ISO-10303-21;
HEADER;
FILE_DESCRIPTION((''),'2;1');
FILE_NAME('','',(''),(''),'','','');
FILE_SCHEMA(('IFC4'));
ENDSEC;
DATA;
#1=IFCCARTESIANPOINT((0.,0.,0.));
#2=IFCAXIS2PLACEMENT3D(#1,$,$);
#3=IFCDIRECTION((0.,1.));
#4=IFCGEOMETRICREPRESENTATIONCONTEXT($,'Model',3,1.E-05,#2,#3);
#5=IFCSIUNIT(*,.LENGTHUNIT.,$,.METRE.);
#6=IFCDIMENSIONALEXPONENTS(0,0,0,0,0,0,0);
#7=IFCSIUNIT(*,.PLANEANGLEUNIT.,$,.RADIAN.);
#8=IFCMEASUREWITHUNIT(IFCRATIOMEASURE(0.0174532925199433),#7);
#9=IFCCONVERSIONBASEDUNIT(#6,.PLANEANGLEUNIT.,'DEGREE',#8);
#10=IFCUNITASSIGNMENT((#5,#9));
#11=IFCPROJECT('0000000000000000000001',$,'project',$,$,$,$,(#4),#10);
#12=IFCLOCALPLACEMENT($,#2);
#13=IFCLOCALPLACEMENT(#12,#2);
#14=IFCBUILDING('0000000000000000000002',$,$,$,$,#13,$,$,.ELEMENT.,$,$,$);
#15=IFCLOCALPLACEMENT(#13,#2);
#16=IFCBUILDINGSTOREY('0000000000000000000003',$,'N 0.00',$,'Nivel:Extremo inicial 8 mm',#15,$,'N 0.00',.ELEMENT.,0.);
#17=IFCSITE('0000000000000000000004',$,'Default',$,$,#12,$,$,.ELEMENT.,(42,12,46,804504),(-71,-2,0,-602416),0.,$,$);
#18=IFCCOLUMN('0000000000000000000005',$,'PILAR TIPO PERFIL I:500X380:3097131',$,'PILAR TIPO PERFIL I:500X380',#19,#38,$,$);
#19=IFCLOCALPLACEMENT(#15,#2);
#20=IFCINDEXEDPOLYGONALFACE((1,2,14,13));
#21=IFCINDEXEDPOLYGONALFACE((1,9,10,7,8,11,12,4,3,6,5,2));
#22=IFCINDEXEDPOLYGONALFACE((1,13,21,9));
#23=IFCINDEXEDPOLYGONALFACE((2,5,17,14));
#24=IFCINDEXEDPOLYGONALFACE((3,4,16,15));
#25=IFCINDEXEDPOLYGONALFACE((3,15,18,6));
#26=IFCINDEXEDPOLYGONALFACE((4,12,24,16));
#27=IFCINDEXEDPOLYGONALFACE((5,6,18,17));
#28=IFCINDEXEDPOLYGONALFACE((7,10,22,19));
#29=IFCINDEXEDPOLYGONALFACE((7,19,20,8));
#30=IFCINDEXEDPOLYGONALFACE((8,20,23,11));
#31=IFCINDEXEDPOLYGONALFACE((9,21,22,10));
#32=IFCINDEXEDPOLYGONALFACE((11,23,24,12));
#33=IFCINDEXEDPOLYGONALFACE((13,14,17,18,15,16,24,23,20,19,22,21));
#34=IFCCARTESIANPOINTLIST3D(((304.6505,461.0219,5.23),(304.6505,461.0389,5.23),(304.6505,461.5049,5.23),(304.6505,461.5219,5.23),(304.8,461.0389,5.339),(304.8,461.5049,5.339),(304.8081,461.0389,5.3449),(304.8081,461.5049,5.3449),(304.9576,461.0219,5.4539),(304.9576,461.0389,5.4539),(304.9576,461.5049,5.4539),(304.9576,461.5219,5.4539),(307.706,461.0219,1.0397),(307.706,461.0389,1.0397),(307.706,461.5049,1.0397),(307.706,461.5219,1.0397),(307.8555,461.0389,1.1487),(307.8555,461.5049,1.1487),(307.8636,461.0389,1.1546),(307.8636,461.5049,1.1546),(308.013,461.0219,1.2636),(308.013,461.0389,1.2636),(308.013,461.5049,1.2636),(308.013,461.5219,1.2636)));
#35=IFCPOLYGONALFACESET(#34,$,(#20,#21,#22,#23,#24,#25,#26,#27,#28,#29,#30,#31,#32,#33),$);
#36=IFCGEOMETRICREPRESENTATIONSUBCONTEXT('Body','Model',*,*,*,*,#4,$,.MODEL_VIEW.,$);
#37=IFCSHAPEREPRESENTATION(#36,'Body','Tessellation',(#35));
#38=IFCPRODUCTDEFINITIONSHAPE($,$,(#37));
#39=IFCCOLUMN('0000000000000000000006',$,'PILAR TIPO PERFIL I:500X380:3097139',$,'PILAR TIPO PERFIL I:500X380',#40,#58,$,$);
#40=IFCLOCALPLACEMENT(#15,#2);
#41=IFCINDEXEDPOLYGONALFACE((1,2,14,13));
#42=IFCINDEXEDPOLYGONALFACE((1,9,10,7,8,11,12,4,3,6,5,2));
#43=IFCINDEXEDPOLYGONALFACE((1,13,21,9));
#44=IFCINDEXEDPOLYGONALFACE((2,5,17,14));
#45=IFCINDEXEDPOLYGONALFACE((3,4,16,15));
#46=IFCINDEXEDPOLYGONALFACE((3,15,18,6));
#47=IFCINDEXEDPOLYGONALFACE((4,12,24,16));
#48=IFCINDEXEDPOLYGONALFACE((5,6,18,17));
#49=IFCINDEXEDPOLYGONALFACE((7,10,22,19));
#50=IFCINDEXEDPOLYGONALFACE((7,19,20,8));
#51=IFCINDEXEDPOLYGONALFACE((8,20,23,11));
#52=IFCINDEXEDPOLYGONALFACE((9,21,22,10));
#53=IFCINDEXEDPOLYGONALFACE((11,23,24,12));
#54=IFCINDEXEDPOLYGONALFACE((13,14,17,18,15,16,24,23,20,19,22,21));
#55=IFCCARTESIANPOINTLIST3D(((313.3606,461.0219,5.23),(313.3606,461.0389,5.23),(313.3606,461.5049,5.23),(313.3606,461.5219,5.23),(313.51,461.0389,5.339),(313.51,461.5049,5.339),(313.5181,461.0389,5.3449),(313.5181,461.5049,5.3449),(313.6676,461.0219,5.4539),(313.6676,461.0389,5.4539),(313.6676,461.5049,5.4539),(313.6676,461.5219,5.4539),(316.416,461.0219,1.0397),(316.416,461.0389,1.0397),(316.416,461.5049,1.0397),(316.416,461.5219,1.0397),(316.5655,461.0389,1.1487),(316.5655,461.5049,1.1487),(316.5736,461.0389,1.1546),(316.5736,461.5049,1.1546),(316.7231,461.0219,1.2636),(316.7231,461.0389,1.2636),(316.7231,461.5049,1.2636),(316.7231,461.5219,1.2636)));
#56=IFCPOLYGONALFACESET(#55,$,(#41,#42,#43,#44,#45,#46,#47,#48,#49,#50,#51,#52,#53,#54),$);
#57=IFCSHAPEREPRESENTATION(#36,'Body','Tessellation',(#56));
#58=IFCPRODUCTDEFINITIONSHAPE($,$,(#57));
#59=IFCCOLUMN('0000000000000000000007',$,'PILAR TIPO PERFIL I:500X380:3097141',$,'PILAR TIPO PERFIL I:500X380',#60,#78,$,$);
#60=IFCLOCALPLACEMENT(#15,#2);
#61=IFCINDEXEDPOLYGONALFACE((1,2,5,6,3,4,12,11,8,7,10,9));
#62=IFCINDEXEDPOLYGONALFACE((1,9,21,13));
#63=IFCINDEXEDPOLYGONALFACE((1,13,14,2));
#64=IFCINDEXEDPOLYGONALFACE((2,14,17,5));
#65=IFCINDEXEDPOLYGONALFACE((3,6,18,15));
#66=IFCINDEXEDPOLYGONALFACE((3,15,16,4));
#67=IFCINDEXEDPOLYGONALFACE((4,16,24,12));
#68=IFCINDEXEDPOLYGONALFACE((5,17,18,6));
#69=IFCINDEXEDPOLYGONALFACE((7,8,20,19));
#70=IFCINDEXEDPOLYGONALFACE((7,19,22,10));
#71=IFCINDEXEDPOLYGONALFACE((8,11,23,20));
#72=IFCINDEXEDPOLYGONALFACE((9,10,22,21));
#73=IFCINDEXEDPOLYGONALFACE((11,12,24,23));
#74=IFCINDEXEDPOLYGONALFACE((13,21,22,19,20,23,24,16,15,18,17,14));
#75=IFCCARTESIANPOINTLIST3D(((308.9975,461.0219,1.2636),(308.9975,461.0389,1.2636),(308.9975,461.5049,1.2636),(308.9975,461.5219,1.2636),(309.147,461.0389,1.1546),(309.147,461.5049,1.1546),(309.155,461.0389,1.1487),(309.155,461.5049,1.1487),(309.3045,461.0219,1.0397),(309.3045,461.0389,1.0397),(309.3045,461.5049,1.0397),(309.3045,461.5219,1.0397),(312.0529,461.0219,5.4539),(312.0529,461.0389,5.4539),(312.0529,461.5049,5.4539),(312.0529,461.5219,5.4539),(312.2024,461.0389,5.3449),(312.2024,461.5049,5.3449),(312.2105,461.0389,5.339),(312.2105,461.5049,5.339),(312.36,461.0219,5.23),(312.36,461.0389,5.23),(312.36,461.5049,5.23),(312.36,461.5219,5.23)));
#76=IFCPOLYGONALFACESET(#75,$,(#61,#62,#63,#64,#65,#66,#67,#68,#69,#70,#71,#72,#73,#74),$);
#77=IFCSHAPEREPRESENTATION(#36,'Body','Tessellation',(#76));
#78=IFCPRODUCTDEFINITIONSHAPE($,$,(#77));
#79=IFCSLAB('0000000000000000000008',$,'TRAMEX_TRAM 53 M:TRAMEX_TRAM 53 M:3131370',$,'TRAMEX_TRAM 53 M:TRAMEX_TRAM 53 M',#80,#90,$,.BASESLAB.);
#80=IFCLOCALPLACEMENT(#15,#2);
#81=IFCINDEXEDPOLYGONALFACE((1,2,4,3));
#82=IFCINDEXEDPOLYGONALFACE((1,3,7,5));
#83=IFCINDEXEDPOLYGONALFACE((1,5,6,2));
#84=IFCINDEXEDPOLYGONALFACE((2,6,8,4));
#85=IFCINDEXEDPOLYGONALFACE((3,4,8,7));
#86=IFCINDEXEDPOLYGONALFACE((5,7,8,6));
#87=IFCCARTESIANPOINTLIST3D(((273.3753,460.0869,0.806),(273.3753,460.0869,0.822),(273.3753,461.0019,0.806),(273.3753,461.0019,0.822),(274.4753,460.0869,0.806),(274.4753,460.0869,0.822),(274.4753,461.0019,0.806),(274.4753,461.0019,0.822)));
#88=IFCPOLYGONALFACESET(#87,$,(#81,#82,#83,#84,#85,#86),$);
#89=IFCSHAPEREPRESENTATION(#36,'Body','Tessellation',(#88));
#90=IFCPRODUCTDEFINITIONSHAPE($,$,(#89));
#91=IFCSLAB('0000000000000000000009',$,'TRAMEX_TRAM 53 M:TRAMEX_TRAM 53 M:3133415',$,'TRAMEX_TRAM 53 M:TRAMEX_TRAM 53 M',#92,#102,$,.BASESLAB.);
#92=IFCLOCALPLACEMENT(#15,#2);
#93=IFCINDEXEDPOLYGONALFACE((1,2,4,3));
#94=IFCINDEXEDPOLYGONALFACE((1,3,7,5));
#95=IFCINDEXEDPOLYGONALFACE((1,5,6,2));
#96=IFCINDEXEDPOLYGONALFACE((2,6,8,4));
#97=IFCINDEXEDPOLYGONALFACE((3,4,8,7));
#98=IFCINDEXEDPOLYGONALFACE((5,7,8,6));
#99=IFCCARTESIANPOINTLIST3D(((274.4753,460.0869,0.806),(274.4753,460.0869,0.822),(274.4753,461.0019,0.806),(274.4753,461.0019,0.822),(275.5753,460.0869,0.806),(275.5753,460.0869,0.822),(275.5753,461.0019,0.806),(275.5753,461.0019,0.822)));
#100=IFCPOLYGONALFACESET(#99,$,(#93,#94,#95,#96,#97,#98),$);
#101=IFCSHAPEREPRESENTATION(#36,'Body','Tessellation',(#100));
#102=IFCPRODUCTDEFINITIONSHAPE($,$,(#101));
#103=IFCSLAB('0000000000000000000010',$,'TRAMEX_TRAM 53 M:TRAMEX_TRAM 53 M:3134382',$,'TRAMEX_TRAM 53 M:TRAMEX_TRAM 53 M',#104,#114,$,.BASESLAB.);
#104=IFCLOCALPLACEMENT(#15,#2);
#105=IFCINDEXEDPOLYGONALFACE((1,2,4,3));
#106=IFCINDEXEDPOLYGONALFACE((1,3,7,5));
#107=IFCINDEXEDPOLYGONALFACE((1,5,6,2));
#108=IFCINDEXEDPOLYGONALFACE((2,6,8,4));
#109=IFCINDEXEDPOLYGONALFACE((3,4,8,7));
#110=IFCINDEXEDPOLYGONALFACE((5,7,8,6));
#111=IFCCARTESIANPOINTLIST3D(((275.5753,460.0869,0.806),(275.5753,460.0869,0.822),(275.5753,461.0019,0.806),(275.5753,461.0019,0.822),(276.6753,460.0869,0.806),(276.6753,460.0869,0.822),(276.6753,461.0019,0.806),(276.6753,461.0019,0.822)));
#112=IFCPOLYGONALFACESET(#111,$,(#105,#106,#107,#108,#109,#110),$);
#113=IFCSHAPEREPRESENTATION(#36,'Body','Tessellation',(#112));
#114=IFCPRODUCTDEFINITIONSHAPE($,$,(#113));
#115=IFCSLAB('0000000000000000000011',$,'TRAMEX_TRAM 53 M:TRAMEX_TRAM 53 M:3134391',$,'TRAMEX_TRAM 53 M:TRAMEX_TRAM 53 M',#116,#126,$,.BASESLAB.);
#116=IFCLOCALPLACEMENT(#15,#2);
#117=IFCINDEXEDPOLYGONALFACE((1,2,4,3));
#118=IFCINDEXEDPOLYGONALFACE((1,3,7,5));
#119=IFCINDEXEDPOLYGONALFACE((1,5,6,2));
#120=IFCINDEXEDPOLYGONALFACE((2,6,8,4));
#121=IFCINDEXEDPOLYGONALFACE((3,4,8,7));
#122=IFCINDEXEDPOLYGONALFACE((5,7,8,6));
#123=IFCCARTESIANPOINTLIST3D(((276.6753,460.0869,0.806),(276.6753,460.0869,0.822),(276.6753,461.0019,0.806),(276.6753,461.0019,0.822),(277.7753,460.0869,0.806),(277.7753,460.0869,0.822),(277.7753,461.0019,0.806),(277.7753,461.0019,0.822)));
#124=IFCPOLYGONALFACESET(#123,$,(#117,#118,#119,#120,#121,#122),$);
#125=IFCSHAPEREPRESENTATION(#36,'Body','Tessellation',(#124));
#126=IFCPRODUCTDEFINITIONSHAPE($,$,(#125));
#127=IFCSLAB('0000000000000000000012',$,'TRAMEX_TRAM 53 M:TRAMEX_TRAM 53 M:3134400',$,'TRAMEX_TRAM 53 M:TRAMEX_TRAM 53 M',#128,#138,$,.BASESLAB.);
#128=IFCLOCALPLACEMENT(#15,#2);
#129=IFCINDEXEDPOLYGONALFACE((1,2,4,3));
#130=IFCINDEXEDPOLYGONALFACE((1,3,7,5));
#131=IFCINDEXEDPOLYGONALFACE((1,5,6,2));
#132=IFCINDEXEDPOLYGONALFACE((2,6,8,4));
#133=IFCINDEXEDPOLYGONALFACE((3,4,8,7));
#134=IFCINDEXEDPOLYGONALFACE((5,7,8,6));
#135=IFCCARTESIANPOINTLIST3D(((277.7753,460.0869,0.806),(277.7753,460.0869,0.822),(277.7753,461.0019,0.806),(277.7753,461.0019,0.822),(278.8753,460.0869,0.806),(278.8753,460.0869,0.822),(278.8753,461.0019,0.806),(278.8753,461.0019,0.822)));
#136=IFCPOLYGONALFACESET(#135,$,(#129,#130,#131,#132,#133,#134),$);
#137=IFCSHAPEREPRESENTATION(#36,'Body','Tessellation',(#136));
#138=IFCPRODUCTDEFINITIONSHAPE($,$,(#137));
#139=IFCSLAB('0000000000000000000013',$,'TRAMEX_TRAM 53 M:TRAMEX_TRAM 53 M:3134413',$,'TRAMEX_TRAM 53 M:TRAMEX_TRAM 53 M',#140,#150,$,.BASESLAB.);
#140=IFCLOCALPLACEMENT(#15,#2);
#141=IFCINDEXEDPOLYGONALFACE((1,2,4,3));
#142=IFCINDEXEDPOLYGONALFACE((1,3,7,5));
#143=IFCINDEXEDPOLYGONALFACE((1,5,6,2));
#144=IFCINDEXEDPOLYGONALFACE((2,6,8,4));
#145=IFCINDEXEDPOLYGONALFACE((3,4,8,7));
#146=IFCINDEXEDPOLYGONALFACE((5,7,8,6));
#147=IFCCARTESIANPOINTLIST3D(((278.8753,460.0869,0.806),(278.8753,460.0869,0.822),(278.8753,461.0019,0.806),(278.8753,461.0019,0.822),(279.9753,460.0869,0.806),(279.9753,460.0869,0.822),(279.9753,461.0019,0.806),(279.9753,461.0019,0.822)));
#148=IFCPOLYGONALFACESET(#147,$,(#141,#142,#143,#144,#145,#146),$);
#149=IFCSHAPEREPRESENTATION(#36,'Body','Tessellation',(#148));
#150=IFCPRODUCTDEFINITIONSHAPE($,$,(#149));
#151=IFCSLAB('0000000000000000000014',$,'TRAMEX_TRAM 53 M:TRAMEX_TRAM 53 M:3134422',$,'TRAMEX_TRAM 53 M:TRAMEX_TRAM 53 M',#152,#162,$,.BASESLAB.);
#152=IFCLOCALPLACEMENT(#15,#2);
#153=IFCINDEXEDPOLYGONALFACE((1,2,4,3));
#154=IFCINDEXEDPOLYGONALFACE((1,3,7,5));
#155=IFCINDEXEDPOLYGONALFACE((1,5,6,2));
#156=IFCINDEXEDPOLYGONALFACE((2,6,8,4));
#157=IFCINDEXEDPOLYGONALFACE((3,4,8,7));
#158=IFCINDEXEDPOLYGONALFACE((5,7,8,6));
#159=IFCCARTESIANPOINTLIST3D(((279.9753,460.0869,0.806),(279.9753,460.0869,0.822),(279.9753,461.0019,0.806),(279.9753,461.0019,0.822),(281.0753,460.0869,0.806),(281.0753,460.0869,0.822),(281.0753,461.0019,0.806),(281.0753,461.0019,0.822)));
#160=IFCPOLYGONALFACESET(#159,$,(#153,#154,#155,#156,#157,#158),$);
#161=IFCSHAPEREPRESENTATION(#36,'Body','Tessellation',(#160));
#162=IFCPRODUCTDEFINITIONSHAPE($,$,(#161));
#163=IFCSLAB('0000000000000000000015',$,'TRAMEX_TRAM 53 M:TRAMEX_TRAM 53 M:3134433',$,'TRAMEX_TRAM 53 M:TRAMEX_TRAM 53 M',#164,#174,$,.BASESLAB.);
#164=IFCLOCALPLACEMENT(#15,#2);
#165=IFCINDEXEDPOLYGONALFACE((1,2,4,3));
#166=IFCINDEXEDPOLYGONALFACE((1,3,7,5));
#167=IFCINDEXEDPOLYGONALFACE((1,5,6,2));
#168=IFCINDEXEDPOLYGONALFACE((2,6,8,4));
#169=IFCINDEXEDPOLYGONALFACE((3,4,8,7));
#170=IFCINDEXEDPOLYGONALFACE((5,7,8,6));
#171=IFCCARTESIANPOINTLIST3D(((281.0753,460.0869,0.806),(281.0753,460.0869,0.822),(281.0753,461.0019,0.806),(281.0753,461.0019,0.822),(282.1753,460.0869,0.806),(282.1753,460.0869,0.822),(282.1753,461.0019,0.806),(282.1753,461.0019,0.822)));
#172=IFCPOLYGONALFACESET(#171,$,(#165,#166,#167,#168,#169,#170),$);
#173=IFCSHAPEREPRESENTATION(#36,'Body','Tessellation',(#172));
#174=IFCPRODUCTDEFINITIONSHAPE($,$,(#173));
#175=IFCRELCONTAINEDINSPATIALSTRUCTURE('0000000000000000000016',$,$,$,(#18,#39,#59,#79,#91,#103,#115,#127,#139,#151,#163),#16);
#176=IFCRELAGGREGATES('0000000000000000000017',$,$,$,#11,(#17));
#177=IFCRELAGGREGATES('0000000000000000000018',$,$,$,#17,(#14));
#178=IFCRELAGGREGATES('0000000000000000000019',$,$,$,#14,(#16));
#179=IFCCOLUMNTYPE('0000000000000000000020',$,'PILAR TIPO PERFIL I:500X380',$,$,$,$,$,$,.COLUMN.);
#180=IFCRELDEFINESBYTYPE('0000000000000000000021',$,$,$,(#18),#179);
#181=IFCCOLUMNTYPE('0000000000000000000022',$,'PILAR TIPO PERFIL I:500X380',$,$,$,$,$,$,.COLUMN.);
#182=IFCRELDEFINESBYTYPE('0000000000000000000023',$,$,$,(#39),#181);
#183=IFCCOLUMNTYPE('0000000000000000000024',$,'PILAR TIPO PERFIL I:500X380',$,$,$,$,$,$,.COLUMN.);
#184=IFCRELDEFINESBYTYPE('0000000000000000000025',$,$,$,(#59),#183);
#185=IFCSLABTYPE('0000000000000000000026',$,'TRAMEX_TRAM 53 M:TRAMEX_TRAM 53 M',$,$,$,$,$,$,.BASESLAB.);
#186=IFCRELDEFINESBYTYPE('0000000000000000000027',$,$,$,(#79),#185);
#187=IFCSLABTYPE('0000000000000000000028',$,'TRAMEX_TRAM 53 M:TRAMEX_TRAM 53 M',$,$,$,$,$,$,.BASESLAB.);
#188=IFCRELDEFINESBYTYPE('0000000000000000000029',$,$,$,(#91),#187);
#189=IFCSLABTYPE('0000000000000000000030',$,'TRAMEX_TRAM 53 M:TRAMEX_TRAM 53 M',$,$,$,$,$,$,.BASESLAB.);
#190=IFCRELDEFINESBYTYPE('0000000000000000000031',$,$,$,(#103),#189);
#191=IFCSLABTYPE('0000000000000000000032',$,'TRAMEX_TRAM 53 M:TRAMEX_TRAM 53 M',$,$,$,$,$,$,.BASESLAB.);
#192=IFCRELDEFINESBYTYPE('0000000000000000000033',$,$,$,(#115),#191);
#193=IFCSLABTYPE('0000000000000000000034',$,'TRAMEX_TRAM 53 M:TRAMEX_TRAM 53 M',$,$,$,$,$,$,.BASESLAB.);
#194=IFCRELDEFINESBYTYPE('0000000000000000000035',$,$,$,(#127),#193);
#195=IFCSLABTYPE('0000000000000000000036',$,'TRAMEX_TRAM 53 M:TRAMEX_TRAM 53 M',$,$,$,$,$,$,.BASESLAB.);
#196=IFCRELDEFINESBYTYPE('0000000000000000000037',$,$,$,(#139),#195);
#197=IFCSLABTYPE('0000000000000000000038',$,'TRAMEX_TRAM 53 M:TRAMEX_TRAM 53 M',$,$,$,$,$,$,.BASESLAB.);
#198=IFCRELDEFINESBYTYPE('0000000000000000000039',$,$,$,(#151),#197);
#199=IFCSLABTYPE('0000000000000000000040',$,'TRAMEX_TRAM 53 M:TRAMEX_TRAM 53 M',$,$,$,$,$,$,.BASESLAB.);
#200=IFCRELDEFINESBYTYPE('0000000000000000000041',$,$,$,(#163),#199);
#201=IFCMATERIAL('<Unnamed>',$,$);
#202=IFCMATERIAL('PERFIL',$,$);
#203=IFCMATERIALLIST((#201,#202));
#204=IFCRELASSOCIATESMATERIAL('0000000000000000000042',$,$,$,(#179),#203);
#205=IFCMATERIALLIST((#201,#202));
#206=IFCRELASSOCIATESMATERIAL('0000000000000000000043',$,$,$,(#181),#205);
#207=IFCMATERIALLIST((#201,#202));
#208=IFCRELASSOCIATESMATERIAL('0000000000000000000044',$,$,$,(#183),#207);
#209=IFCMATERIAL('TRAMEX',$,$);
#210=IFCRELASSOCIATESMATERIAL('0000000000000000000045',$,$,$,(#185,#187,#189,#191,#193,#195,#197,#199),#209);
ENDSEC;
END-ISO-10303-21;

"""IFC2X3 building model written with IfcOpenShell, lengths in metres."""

from ifc_helpers import new_model, entity, si_unit, converted_unit, direction, frame, frame_2d, origin, place, context, subcontext, project, spatial, rectangle, i_section, extrude, source, transform, mapped, material, material_list, type_object, type_shapes, element, save


model = new_model("IFC2X3")

# Units and contexts
model_context = context("Model", 3, precision=1e-05, world=origin(), true_north=direction((0.0, 1.0)))
body_context = subcontext(model_context, "Body", "Model", "MODEL_VIEW")
ifc_project = project(units=[si_unit("LENGTHUNIT", "METRE"), converted_unit("PLANEANGLEUNIT", "DEGREE", entity("IfcRatioMeasure", 0.0174532925199433), si_unit("PLANEANGLEUNIT", "RADIAN"), dimensions=[0, 0, 0, 0, 0, 0, 0])], contexts=[model_context])

# Site, building, storey
site_placement = place(None, origin())
site = spatial("IfcSite", under=ifc_project, at=site_placement, Name="Default", CompositionType="ELEMENT", RefLatitude=(42, 12, 46, 804504), RefLongitude=(-71, -2, 0, -602416), RefElevation=0.0)
building_placement = place(site_placement, origin())
building = spatial("IfcBuilding", under=site, at=building_placement, CompositionType="ELEMENT")
storey_placement = place(building_placement, origin())
storey = spatial("IfcBuildingStorey", under=building, at=storey_placement, Name="N 0.00", ObjectType="Nivel:Extremo inicial 8 mm", LongName="N 0.00", CompositionType="ELEMENT", Elevation=0.0)

# Columns
ifc_material_1 = material(Name="<Unnamed>")
ifc_material_2 = material(Name="PERFIL")
ifc_material_list_1 = material_list([ifc_material_1, ifc_material_2])
column_type_1 = type_object("IfcColumnType", Name="PILAR TIPO PERFIL I:500X380", PredefinedType="COLUMN", material=ifc_material_list_1)
shared_shape_1 = source(origin(), body_context, "Body", "SweptSolid", [
    extrude(i_section(OverallWidth=0.38, OverallDepth=0.5, WebThickness=0.01, FlangeThickness=0.017, at=frame_2d((0.0, 0.0), x_axis=(0.0, 1.0))), frame((307.8595, 461.2719, 1.1516), z_axis=(-0.589174, 0.0, 0.808006), x_axis=(0.0, -1.0, 0.0)), (0.0, 0.0, 1.0), 5.186),
])
type_shapes(column_type_1, [shared_shape_1])
column_1_placement = place(storey_placement, origin())
element("IfcColumn", 1, at=column_1_placement, inside=storey, type_object=column_type_1, Name="PILAR TIPO PERFIL I:500X380:3097131", ObjectType="PILAR TIPO PERFIL I:500X380", context=body_context, shape_type="MappedRepresentation", body=[
    mapped(shared_shape_1, transform((0.0, 0.0, 0.0), scale=1.0)),
])
ifc_material_list_2 = material_list([ifc_material_1, ifc_material_2])
column_type_2 = type_object("IfcColumnType", Name="PILAR TIPO PERFIL I:500X380", PredefinedType="COLUMN", material=ifc_material_list_2)
shared_shape_2 = source(origin(), body_context, "Body", "SweptSolid", [
    extrude(i_section(OverallWidth=0.38, OverallDepth=0.5, WebThickness=0.01, FlangeThickness=0.017, at=frame_2d((0.0, 0.0), x_axis=(0.0, 1.0))), frame((316.5695, 461.2719, 1.1516), z_axis=(-0.589174, 0.0, 0.808006), x_axis=(0.0, -1.0, 0.0)), (0.0, 0.0, 1.0), 5.186),
])
type_shapes(column_type_2, [shared_shape_2])
column_2_placement = place(storey_placement, origin())
element("IfcColumn", 2, at=column_2_placement, inside=storey, type_object=column_type_2, Name="PILAR TIPO PERFIL I:500X380:3097139", ObjectType="PILAR TIPO PERFIL I:500X380", context=body_context, shape_type="MappedRepresentation", body=[
    mapped(shared_shape_2, transform((0.0, 0.0, 0.0), scale=1.0)),
])
ifc_material_list_3 = material_list([ifc_material_1, ifc_material_2])
column_type_3 = type_object("IfcColumnType", Name="PILAR TIPO PERFIL I:500X380", PredefinedType="COLUMN", material=ifc_material_list_3)
shared_shape_3 = source(origin(), body_context, "Body", "SweptSolid", [
    extrude(i_section(OverallWidth=0.38, OverallDepth=0.5, WebThickness=0.01, FlangeThickness=0.017, at=frame_2d((0.0, 0.0), x_axis=(0.0, 1.0))), frame((309.151, 461.2719, 1.1516), z_axis=(0.589174, 0.0, 0.808006), x_axis=(0.0, -1.0, 0.0)), (0.0, 0.0, 1.0), 5.186),
])
type_shapes(column_type_3, [shared_shape_3])
column_3_placement = place(storey_placement, origin())
element("IfcColumn", 3, at=column_3_placement, inside=storey, type_object=column_type_3, Name="PILAR TIPO PERFIL I:500X380:3097141", ObjectType="PILAR TIPO PERFIL I:500X380", context=body_context, shape_type="MappedRepresentation", body=[
    mapped(shared_shape_3, transform((0.0, 0.0, 0.0), scale=1.0)),
])

# Slabs
ifc_material_3 = material(Name="TRAMEX")
slab_type_1 = type_object("IfcSlabType", Name="TRAMEX_TRAM 53 M:TRAMEX_TRAM 53 M", PredefinedType="BASESLAB", material=ifc_material_3)
slab_1_placement = place(storey_placement, origin())
element("IfcSlab", 4, at=slab_1_placement, inside=storey, type_object=slab_type_1, Name="TRAMEX_TRAM 53 M:TRAMEX_TRAM 53 M:3131370", ObjectType="TRAMEX_TRAM 53 M:TRAMEX_TRAM 53 M", PredefinedType="BASESLAB", context=body_context, shape_type="SweptSolid", body=[
    extrude(rectangle(XDim=0.915, YDim=1.1, at=frame_2d((0.0, 0.0), x_axis=(1.0, 0.0))), frame((273.9253, 460.5444, 0.806), z_axis=(0.0, 0.0, 1.0), x_axis=(0.0, 1.0, 0.0)), (0.0, 0.0, 1.0), 0.016),
])
slab_type_2 = type_object("IfcSlabType", Name="TRAMEX_TRAM 53 M:TRAMEX_TRAM 53 M", PredefinedType="BASESLAB", material=ifc_material_3)
slab_2_placement = place(storey_placement, origin())
element("IfcSlab", 5, at=slab_2_placement, inside=storey, type_object=slab_type_2, Name="TRAMEX_TRAM 53 M:TRAMEX_TRAM 53 M:3133415", ObjectType="TRAMEX_TRAM 53 M:TRAMEX_TRAM 53 M", PredefinedType="BASESLAB", context=body_context, shape_type="SweptSolid", body=[
    extrude(rectangle(XDim=0.915, YDim=1.1, at=frame_2d((0.0, 0.0), x_axis=(1.0, 0.0))), frame((275.0253, 460.5444, 0.806), z_axis=(0.0, 0.0, 1.0), x_axis=(0.0, 1.0, 0.0)), (0.0, 0.0, 1.0), 0.016),
])
slab_type_3 = type_object("IfcSlabType", Name="TRAMEX_TRAM 53 M:TRAMEX_TRAM 53 M", PredefinedType="BASESLAB", material=ifc_material_3)
slab_3_placement = place(storey_placement, origin())
element("IfcSlab", 6, at=slab_3_placement, inside=storey, type_object=slab_type_3, Name="TRAMEX_TRAM 53 M:TRAMEX_TRAM 53 M:3134382", ObjectType="TRAMEX_TRAM 53 M:TRAMEX_TRAM 53 M", PredefinedType="BASESLAB", context=body_context, shape_type="SweptSolid", body=[
    extrude(rectangle(XDim=0.915, YDim=1.1, at=frame_2d((0.0, 0.0), x_axis=(1.0, 0.0))), frame((276.1253, 460.5444, 0.806), z_axis=(0.0, 0.0, 1.0), x_axis=(0.0, 1.0, 0.0)), (0.0, 0.0, 1.0), 0.016),
])
slab_type_4 = type_object("IfcSlabType", Name="TRAMEX_TRAM 53 M:TRAMEX_TRAM 53 M", PredefinedType="BASESLAB", material=ifc_material_3)
slab_4_placement = place(storey_placement, origin())
element("IfcSlab", 7, at=slab_4_placement, inside=storey, type_object=slab_type_4, Name="TRAMEX_TRAM 53 M:TRAMEX_TRAM 53 M:3134391", ObjectType="TRAMEX_TRAM 53 M:TRAMEX_TRAM 53 M", PredefinedType="BASESLAB", context=body_context, shape_type="SweptSolid", body=[
    extrude(rectangle(XDim=0.915, YDim=1.1, at=frame_2d((0.0, 0.0), x_axis=(1.0, 0.0))), frame((277.2253, 460.5444, 0.806), z_axis=(0.0, 0.0, 1.0), x_axis=(0.0, 1.0, 0.0)), (0.0, 0.0, 1.0), 0.016),
])
slab_type_5 = type_object("IfcSlabType", Name="TRAMEX_TRAM 53 M:TRAMEX_TRAM 53 M", PredefinedType="BASESLAB", material=ifc_material_3)
slab_5_placement = place(storey_placement, origin())
element("IfcSlab", 8, at=slab_5_placement, inside=storey, type_object=slab_type_5, Name="TRAMEX_TRAM 53 M:TRAMEX_TRAM 53 M:3134400", ObjectType="TRAMEX_TRAM 53 M:TRAMEX_TRAM 53 M", PredefinedType="BASESLAB", context=body_context, shape_type="SweptSolid", body=[
    extrude(rectangle(XDim=0.915, YDim=1.1, at=frame_2d((0.0, 0.0), x_axis=(1.0, 0.0))), frame((278.3253, 460.5444, 0.806), z_axis=(0.0, 0.0, 1.0), x_axis=(0.0, 1.0, 0.0)), (0.0, 0.0, 1.0), 0.016),
])
slab_type_6 = type_object("IfcSlabType", Name="TRAMEX_TRAM 53 M:TRAMEX_TRAM 53 M", PredefinedType="BASESLAB", material=ifc_material_3)
slab_6_placement = place(storey_placement, origin())
element("IfcSlab", 9, at=slab_6_placement, inside=storey, type_object=slab_type_6, Name="TRAMEX_TRAM 53 M:TRAMEX_TRAM 53 M:3134413", ObjectType="TRAMEX_TRAM 53 M:TRAMEX_TRAM 53 M", PredefinedType="BASESLAB", context=body_context, shape_type="SweptSolid", body=[
    extrude(rectangle(XDim=0.915, YDim=1.1, at=frame_2d((0.0, 0.0), x_axis=(1.0, 0.0))), frame((279.4253, 460.5444, 0.806), z_axis=(0.0, 0.0, 1.0), x_axis=(0.0, 1.0, 0.0)), (0.0, 0.0, 1.0), 0.016),
])
slab_type_7 = type_object("IfcSlabType", Name="TRAMEX_TRAM 53 M:TRAMEX_TRAM 53 M", PredefinedType="BASESLAB", material=ifc_material_3)
slab_7_placement = place(storey_placement, origin())
element("IfcSlab", 10, at=slab_7_placement, inside=storey, type_object=slab_type_7, Name="TRAMEX_TRAM 53 M:TRAMEX_TRAM 53 M:3134422", ObjectType="TRAMEX_TRAM 53 M:TRAMEX_TRAM 53 M", PredefinedType="BASESLAB", context=body_context, shape_type="SweptSolid", body=[
    extrude(rectangle(XDim=0.915, YDim=1.1, at=frame_2d((0.0, 0.0), x_axis=(1.0, 0.0))), frame((280.5253, 460.5444, 0.806), z_axis=(0.0, 0.0, 1.0), x_axis=(0.0, 1.0, 0.0)), (0.0, 0.0, 1.0), 0.016),
])
slab_type_8 = type_object("IfcSlabType", Name="TRAMEX_TRAM 53 M:TRAMEX_TRAM 53 M", PredefinedType="BASESLAB", material=ifc_material_3)
slab_8_placement = place(storey_placement, origin())
element("IfcSlab", 11, at=slab_8_placement, inside=storey, type_object=slab_type_8, Name="TRAMEX_TRAM 53 M:TRAMEX_TRAM 53 M:3134433", ObjectType="TRAMEX_TRAM 53 M:TRAMEX_TRAM 53 M", PredefinedType="BASESLAB", context=body_context, shape_type="SweptSolid", body=[
    extrude(rectangle(XDim=0.915, YDim=1.1, at=frame_2d((0.0, 0.0), x_axis=(1.0, 0.0))), frame((281.6253, 460.5444, 0.806), z_axis=(0.0, 0.0, 1.0), x_axis=(0.0, 1.0, 0.0)), (0.0, 0.0, 1.0), 0.016),
])

save(model, "model.ifc")
